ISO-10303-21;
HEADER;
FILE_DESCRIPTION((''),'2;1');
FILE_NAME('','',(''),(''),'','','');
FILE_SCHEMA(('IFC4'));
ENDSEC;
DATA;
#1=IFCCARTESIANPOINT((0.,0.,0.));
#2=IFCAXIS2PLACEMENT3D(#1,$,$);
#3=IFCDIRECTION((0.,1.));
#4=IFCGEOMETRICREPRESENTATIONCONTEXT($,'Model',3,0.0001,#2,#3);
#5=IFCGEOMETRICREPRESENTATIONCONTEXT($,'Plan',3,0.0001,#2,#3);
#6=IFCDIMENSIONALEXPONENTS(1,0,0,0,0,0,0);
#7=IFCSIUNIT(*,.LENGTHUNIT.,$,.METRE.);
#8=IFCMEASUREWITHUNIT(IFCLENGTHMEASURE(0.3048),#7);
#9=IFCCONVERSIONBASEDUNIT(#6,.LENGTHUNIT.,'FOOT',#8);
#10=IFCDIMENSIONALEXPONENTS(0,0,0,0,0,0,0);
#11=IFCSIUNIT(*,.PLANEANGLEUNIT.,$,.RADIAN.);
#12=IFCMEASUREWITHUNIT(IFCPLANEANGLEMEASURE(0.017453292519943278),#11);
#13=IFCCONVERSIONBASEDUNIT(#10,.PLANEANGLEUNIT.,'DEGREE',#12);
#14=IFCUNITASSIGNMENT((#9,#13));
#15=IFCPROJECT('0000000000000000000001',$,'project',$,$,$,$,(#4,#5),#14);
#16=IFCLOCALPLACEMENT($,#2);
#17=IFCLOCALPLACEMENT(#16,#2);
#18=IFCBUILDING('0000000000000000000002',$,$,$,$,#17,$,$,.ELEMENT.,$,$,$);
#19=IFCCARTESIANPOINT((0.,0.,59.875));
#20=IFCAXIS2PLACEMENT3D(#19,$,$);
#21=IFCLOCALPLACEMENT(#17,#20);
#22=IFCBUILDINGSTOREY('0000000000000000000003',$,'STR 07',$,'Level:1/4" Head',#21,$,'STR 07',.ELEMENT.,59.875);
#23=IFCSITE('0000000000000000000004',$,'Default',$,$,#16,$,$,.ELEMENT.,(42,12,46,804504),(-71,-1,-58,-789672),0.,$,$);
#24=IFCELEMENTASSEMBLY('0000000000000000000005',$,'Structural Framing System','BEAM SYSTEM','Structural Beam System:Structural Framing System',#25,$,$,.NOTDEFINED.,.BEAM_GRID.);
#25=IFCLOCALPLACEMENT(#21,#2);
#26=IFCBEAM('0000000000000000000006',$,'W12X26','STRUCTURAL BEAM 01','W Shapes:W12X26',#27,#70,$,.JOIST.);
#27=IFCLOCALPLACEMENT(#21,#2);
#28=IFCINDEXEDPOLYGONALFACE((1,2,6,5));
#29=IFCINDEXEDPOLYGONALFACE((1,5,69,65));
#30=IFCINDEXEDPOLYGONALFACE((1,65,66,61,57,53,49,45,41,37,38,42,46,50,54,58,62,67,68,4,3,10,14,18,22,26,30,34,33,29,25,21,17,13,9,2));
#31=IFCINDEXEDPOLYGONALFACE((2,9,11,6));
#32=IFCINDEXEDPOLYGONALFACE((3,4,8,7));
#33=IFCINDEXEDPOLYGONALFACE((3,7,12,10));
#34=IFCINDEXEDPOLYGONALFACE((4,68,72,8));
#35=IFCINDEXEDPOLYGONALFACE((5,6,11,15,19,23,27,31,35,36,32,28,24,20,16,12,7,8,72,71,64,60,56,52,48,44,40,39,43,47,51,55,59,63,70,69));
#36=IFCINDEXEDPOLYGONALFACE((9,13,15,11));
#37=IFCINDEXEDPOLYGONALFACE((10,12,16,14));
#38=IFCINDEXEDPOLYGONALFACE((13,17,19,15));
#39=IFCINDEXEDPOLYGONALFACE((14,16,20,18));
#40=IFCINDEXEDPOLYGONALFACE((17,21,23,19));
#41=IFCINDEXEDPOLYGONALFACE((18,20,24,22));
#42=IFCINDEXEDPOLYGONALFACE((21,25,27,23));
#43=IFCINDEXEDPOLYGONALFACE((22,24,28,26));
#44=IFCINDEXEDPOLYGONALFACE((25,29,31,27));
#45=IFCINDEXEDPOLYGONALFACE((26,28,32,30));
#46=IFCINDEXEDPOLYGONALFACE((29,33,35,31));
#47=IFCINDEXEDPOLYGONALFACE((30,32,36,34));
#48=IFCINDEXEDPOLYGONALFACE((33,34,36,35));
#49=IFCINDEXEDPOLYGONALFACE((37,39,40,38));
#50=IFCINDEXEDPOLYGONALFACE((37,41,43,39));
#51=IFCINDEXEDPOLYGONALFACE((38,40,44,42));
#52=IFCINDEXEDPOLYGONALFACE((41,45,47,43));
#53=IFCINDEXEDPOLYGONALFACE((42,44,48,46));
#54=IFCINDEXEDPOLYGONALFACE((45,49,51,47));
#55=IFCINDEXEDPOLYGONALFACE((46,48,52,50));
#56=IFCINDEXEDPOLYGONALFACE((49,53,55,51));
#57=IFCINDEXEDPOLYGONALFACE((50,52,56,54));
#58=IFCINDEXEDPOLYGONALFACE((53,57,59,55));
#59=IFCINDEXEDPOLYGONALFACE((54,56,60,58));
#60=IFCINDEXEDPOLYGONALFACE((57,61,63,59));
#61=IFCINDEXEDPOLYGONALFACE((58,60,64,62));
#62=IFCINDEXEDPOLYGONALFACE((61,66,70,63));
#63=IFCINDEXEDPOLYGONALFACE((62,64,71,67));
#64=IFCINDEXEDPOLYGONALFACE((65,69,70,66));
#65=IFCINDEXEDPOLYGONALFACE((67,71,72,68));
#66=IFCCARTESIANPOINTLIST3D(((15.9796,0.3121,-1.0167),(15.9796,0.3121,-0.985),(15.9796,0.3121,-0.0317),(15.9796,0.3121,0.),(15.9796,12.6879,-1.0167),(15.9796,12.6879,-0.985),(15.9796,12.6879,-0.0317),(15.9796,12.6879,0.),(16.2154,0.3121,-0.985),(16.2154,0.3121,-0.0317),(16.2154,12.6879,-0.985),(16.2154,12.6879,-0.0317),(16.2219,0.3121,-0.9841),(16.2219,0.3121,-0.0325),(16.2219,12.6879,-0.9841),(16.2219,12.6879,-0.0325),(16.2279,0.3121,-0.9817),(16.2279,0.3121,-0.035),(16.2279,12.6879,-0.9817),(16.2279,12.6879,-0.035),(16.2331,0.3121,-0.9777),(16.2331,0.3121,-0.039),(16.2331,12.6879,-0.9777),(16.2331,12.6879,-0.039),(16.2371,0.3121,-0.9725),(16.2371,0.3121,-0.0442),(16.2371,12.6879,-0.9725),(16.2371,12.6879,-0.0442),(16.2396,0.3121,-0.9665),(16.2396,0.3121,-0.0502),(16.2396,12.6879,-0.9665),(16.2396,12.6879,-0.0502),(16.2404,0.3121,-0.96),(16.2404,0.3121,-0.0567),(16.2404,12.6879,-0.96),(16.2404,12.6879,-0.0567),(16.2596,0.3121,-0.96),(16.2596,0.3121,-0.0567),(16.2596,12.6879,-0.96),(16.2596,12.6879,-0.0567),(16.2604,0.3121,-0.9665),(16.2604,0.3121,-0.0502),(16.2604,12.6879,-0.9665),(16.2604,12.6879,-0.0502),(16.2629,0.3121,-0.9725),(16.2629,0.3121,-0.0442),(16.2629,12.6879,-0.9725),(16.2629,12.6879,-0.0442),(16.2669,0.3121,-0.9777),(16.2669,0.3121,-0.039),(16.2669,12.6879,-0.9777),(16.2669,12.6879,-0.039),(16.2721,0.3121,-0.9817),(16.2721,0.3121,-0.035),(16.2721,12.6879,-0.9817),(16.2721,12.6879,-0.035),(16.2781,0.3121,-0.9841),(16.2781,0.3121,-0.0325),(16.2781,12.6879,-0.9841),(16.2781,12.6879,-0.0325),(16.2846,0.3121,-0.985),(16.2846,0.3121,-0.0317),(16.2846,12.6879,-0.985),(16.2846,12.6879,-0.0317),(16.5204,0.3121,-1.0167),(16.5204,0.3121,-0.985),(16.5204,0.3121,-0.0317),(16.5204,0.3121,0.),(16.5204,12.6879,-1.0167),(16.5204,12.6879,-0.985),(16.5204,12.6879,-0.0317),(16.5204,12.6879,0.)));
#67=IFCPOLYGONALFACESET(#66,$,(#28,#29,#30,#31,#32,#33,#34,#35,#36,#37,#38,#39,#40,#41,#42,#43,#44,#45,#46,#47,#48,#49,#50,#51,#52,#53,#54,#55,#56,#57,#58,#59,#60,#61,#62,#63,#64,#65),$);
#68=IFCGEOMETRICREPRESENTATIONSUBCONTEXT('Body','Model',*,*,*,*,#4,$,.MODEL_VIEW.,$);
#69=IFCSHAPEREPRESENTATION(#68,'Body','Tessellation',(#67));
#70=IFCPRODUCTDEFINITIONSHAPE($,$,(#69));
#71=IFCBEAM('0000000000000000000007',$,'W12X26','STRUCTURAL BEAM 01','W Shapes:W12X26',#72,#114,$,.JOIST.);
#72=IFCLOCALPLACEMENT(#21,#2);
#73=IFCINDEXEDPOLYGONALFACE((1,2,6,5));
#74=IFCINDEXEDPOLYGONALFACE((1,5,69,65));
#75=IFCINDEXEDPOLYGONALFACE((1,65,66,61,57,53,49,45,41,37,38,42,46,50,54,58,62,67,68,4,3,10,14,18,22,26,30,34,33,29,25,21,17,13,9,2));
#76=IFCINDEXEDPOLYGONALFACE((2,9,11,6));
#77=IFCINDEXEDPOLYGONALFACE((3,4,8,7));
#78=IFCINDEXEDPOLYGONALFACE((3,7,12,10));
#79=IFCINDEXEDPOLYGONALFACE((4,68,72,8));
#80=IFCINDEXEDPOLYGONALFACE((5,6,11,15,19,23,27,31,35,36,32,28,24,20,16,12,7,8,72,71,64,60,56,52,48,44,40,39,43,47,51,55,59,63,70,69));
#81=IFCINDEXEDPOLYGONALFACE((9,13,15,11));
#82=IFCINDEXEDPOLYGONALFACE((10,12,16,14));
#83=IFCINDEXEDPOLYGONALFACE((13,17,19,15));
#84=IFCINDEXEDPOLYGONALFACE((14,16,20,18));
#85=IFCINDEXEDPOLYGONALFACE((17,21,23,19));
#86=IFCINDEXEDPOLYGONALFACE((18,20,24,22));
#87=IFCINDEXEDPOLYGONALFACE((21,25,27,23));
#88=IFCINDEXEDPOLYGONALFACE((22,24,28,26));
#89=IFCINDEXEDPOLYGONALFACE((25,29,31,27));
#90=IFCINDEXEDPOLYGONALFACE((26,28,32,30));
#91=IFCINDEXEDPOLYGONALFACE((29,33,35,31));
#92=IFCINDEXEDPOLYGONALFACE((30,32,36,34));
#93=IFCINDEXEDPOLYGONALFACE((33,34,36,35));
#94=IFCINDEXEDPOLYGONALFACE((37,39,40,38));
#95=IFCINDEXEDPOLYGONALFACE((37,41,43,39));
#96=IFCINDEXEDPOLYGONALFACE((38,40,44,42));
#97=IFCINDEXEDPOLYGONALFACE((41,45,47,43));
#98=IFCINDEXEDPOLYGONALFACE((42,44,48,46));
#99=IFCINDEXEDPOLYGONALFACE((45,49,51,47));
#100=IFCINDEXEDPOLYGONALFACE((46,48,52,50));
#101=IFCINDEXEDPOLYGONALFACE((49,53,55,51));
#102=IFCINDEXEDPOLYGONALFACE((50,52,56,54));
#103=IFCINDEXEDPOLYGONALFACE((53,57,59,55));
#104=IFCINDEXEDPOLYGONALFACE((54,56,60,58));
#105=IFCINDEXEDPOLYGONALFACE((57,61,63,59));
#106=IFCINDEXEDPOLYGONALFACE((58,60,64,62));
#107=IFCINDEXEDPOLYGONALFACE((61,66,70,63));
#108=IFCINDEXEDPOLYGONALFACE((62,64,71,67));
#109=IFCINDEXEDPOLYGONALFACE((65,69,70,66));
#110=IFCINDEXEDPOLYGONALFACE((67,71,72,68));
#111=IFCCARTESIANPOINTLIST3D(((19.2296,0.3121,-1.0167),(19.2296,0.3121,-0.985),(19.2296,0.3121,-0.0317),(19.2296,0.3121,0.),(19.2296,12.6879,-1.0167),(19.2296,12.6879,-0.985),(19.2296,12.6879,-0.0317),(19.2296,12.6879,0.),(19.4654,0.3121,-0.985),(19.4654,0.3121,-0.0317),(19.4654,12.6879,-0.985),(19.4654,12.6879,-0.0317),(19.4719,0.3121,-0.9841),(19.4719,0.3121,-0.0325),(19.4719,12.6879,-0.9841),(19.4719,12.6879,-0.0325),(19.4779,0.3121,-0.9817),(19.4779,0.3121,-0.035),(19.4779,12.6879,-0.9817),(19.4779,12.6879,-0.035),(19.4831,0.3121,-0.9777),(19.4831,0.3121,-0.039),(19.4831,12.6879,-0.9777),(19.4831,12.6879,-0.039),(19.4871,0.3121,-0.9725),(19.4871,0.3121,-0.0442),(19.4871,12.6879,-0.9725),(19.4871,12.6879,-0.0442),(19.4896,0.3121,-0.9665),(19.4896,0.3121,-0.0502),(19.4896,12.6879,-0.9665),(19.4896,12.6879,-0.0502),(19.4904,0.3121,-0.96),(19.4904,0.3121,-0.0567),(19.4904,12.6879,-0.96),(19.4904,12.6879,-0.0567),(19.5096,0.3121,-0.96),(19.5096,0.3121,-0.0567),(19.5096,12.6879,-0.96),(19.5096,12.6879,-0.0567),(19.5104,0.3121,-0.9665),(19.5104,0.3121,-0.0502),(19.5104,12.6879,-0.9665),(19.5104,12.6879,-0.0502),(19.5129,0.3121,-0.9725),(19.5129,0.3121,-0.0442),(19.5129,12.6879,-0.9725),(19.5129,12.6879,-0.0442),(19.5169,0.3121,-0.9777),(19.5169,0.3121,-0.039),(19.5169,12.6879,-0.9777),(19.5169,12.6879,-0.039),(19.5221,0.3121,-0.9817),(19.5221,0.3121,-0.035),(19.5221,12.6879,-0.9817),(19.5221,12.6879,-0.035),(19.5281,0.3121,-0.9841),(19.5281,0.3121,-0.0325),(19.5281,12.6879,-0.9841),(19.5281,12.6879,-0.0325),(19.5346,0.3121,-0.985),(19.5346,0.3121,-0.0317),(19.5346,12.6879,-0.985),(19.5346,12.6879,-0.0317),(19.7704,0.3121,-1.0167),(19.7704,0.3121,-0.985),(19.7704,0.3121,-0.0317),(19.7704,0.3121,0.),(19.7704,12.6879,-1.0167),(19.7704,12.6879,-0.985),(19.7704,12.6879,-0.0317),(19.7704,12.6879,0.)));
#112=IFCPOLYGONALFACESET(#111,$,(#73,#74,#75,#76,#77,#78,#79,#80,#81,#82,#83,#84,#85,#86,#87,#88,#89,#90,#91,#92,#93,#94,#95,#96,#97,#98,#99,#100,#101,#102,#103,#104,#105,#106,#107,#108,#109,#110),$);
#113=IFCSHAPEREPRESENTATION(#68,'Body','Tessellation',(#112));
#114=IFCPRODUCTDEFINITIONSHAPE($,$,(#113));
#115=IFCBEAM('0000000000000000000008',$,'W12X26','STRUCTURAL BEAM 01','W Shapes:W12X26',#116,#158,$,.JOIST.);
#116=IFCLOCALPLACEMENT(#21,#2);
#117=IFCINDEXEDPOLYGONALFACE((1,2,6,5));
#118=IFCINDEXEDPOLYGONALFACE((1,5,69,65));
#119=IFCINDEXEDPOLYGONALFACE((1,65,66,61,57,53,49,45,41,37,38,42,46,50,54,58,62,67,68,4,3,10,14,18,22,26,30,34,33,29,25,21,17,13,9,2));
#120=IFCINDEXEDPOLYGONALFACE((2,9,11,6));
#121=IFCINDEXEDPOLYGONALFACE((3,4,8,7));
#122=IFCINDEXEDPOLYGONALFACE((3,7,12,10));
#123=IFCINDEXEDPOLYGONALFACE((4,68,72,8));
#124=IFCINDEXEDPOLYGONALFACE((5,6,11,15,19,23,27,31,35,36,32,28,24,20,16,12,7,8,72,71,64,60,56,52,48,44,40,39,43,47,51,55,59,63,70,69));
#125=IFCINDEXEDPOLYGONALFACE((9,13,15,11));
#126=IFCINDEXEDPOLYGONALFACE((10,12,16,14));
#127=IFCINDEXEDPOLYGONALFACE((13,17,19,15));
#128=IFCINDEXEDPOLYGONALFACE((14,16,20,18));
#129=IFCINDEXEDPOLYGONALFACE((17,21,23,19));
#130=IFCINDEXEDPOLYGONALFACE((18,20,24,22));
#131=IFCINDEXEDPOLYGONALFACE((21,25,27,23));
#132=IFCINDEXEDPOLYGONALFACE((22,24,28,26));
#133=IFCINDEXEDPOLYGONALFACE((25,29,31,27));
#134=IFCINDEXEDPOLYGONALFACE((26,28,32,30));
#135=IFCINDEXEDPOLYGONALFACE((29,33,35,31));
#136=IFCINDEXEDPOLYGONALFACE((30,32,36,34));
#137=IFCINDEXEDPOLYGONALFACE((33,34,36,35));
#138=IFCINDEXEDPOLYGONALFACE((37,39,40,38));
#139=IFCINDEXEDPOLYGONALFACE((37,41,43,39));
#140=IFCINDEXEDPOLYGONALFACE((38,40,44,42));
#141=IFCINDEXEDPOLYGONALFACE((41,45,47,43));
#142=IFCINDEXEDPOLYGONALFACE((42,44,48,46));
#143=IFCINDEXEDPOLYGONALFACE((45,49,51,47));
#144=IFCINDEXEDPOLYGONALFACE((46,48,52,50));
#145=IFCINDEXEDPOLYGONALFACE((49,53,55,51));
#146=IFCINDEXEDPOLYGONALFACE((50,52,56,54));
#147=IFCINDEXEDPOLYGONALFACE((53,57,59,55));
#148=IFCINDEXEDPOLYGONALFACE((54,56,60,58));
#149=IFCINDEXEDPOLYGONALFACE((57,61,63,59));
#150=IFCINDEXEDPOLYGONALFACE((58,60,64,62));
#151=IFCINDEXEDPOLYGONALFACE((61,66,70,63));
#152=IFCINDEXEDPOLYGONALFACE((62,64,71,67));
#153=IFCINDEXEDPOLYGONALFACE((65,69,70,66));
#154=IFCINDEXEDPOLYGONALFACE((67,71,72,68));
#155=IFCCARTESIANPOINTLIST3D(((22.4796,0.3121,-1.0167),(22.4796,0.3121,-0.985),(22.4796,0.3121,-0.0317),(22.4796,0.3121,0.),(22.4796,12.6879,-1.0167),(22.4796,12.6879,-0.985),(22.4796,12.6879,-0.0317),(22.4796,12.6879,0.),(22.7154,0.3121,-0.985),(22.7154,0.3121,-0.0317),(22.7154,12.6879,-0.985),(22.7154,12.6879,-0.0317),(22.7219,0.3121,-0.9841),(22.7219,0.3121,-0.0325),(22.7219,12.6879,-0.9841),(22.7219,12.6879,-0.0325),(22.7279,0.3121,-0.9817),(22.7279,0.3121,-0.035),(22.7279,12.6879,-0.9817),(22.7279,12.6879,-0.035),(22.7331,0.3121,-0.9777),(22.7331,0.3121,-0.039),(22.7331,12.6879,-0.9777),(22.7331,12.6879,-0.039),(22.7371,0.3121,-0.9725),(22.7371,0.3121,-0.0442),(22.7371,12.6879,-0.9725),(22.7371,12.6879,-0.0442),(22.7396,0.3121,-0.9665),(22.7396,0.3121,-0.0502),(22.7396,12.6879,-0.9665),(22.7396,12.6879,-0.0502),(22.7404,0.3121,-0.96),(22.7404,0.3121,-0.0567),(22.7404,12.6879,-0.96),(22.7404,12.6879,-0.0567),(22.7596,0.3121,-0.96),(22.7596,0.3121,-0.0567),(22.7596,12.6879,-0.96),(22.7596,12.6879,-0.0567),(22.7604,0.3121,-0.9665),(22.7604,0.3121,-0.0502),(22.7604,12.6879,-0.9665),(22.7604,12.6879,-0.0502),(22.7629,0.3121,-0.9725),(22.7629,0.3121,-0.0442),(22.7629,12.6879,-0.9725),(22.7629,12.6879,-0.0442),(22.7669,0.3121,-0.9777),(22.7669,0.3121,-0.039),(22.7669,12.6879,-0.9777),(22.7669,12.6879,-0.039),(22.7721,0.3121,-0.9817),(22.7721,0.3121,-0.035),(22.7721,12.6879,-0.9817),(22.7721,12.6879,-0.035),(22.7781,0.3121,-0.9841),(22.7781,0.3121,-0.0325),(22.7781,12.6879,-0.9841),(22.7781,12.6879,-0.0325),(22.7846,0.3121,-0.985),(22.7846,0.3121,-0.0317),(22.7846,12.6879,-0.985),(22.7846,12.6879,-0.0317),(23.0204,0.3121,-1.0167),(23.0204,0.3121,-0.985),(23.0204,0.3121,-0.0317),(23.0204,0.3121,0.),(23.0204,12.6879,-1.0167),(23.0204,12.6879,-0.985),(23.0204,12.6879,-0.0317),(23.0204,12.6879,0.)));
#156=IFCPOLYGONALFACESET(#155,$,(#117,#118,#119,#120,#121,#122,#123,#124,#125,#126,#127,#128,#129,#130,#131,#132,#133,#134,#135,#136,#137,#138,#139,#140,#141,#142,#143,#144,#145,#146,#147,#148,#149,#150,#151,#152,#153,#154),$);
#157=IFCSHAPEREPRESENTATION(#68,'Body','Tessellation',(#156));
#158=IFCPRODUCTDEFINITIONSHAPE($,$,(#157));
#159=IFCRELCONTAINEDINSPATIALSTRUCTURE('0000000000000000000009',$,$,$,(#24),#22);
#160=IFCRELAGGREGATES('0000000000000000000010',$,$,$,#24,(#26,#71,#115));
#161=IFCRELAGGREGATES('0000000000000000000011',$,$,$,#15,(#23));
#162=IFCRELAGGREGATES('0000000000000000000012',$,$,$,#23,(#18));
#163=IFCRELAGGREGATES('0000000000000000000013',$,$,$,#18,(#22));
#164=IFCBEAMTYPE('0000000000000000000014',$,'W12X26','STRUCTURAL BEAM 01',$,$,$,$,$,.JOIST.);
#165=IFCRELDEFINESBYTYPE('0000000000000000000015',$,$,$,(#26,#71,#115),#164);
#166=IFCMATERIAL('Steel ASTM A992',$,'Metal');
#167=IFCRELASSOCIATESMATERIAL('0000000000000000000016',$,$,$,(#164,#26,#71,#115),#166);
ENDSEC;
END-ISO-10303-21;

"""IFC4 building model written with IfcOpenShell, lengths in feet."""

from ifc_helpers import new_model, entity, si_unit, converted_unit, direction, frame, origin, place, context, subcontext, project, spatial, line, arc, indexed_curve, outline, extrude, source, transform, mapped, material, type_object, type_shapes, element, aggregate, save


model = new_model("IFC4")

# Units and contexts
model_context = context("Model", 3, precision=0.0001, world=origin(), true_north=direction((0.0, 1.0)))
plan_context = context("Plan", 3, precision=0.0001, world=origin(), true_north=direction((0.0, 1.0)))
body_context = subcontext(model_context, "Body", "Model", "MODEL_VIEW")
ifc_project = project(units=[converted_unit("LENGTHUNIT", "FOOT", entity("IfcLengthMeasure", 0.3048), si_unit("LENGTHUNIT", "METRE"), dimensions=[1, 0, 0, 0, 0, 0, 0]), converted_unit("PLANEANGLEUNIT", "DEGREE", entity("IfcPlaneAngleMeasure", 0.017453292519943278), si_unit("PLANEANGLEUNIT", "RADIAN"), dimensions=[0, 0, 0, 0, 0, 0, 0])], contexts=[model_context, plan_context])

# Site, building, storey
site_placement = place(None, origin())
site = spatial("IfcSite", under=ifc_project, at=site_placement, Name="Default", CompositionType="ELEMENT", RefLatitude=(42, 12, 46, 804504), RefLongitude=(-71, -1, -58, -789672), RefElevation=0.0)
building_placement = place(site_placement, origin())
building = spatial("IfcBuilding", under=site, at=building_placement, CompositionType="ELEMENT")
storey_placement = place(building_placement, frame((0.0, 0.0, 59.875)))
storey = spatial("IfcBuildingStorey", under=building, at=storey_placement, Name="STR 07", ObjectType="Level:1/4\" Head", LongName="STR 07", CompositionType="ELEMENT", Elevation=59.875)

# Element assembly, beams
ifc_material = material(Name="Steel ASTM A992", Category="Metal")
beam_type_1 = type_object("IfcBeamType", Name="W12X26", Description="STRUCTURAL BEAM 01", PredefinedType="JOIST", material=ifc_material)
shared_shape = source(origin(), body_context, "Body", "SweptSolid", [
    extrude(outline(indexed_curve([(-0.2704, -0.4767), (-0.2704, -0.5083), (0.2704, -0.5083), (0.2704, -0.4767), (0.0346, -0.4767), (0.0169, -0.4693), (0.0096, -0.4517), (0.0096, 0.4517), (0.0169, 0.4693), (0.0346, 0.4767), (0.2704, 0.4767), (0.2704, 0.5083), (-0.2704, 0.5083), (-0.2704, 0.4767), (-0.0346, 0.4767), (-0.0169, 0.4693), (-0.0096, 0.4517), (-0.0096, -0.4517), (-0.0169, -0.4693), (-0.0346, -0.4767)], segments=[line(1, 2, 3, 4, 5), arc(5, 6, 7), line(7, 8), arc(8, 9, 10), line(10, 11, 12, 13, 14, 15), arc(15, 16, 17), line(17, 18), arc(18, 19, 20), line(20, 1)], self_intersect=False)), frame((-6.1879, 0.0, 0.0), z_axis=(-1.0, 0.0, 0.0), x_axis=(0.0, -1.0, 0.0)), (0.0, 0.0, -1.0), 12.3758),
])
type_shapes(beam_type_1, [shared_shape])
assembly_1_placement = place(storey_placement, origin())
assembly_1 = element("IfcElementAssembly", 1, at=assembly_1_placement, inside=storey, Name="Structural Framing System", Description="BEAM SYSTEM", ObjectType="Structural Beam System:Structural Framing System", AssemblyPlace="NOTDEFINED", PredefinedType="BEAM_GRID")
beam_1_placement = place(assembly_1_placement, frame((16.25, 6.5, -0.5083), z_axis=(0.0, 0.0, 1.0), x_axis=(0.0, 1.0, 0.0)))
beam_1 = element("IfcBeam", 2, at=beam_1_placement, type_object=beam_type_1, material=ifc_material, Name="W12X26", Description="STRUCTURAL BEAM 01", ObjectType="W Shapes:W12X26", PredefinedType="JOIST", context=body_context, shape_type="MappedRepresentation", body=[
    mapped(shared_shape, transform((0.0, 0.0, 0.0), scale=1.0)),
])
beam_2_placement = place(assembly_1_placement, frame((19.5, 6.5, -0.5083), z_axis=(0.0, 0.0, 1.0), x_axis=(0.0, 1.0, 0.0)))
beam_2 = element("IfcBeam", 3, at=beam_2_placement, type_object=beam_type_1, material=ifc_material, Name="W12X26", Description="STRUCTURAL BEAM 01", ObjectType="W Shapes:W12X26", PredefinedType="JOIST", context=body_context, shape_type="MappedRepresentation", body=[
    mapped(shared_shape, transform((0.0, 0.0, 0.0), scale=1.0)),
])
beam_3_placement = place(assembly_1_placement, frame((22.75, 6.5, -0.5083), z_axis=(0.0, 0.0, 1.0), x_axis=(0.0, 1.0, 0.0)))
beam_3 = element("IfcBeam", 4, at=beam_3_placement, type_object=beam_type_1, material=ifc_material, Name="W12X26", Description="STRUCTURAL BEAM 01", ObjectType="W Shapes:W12X26", PredefinedType="JOIST", context=body_context, shape_type="MappedRepresentation", body=[
    mapped(shared_shape, transform((0.0, 0.0, 0.0), scale=1.0)),
])
aggregate(assembly_1, [beam_1, beam_2, beam_3])

save(model, "model.ifc")
